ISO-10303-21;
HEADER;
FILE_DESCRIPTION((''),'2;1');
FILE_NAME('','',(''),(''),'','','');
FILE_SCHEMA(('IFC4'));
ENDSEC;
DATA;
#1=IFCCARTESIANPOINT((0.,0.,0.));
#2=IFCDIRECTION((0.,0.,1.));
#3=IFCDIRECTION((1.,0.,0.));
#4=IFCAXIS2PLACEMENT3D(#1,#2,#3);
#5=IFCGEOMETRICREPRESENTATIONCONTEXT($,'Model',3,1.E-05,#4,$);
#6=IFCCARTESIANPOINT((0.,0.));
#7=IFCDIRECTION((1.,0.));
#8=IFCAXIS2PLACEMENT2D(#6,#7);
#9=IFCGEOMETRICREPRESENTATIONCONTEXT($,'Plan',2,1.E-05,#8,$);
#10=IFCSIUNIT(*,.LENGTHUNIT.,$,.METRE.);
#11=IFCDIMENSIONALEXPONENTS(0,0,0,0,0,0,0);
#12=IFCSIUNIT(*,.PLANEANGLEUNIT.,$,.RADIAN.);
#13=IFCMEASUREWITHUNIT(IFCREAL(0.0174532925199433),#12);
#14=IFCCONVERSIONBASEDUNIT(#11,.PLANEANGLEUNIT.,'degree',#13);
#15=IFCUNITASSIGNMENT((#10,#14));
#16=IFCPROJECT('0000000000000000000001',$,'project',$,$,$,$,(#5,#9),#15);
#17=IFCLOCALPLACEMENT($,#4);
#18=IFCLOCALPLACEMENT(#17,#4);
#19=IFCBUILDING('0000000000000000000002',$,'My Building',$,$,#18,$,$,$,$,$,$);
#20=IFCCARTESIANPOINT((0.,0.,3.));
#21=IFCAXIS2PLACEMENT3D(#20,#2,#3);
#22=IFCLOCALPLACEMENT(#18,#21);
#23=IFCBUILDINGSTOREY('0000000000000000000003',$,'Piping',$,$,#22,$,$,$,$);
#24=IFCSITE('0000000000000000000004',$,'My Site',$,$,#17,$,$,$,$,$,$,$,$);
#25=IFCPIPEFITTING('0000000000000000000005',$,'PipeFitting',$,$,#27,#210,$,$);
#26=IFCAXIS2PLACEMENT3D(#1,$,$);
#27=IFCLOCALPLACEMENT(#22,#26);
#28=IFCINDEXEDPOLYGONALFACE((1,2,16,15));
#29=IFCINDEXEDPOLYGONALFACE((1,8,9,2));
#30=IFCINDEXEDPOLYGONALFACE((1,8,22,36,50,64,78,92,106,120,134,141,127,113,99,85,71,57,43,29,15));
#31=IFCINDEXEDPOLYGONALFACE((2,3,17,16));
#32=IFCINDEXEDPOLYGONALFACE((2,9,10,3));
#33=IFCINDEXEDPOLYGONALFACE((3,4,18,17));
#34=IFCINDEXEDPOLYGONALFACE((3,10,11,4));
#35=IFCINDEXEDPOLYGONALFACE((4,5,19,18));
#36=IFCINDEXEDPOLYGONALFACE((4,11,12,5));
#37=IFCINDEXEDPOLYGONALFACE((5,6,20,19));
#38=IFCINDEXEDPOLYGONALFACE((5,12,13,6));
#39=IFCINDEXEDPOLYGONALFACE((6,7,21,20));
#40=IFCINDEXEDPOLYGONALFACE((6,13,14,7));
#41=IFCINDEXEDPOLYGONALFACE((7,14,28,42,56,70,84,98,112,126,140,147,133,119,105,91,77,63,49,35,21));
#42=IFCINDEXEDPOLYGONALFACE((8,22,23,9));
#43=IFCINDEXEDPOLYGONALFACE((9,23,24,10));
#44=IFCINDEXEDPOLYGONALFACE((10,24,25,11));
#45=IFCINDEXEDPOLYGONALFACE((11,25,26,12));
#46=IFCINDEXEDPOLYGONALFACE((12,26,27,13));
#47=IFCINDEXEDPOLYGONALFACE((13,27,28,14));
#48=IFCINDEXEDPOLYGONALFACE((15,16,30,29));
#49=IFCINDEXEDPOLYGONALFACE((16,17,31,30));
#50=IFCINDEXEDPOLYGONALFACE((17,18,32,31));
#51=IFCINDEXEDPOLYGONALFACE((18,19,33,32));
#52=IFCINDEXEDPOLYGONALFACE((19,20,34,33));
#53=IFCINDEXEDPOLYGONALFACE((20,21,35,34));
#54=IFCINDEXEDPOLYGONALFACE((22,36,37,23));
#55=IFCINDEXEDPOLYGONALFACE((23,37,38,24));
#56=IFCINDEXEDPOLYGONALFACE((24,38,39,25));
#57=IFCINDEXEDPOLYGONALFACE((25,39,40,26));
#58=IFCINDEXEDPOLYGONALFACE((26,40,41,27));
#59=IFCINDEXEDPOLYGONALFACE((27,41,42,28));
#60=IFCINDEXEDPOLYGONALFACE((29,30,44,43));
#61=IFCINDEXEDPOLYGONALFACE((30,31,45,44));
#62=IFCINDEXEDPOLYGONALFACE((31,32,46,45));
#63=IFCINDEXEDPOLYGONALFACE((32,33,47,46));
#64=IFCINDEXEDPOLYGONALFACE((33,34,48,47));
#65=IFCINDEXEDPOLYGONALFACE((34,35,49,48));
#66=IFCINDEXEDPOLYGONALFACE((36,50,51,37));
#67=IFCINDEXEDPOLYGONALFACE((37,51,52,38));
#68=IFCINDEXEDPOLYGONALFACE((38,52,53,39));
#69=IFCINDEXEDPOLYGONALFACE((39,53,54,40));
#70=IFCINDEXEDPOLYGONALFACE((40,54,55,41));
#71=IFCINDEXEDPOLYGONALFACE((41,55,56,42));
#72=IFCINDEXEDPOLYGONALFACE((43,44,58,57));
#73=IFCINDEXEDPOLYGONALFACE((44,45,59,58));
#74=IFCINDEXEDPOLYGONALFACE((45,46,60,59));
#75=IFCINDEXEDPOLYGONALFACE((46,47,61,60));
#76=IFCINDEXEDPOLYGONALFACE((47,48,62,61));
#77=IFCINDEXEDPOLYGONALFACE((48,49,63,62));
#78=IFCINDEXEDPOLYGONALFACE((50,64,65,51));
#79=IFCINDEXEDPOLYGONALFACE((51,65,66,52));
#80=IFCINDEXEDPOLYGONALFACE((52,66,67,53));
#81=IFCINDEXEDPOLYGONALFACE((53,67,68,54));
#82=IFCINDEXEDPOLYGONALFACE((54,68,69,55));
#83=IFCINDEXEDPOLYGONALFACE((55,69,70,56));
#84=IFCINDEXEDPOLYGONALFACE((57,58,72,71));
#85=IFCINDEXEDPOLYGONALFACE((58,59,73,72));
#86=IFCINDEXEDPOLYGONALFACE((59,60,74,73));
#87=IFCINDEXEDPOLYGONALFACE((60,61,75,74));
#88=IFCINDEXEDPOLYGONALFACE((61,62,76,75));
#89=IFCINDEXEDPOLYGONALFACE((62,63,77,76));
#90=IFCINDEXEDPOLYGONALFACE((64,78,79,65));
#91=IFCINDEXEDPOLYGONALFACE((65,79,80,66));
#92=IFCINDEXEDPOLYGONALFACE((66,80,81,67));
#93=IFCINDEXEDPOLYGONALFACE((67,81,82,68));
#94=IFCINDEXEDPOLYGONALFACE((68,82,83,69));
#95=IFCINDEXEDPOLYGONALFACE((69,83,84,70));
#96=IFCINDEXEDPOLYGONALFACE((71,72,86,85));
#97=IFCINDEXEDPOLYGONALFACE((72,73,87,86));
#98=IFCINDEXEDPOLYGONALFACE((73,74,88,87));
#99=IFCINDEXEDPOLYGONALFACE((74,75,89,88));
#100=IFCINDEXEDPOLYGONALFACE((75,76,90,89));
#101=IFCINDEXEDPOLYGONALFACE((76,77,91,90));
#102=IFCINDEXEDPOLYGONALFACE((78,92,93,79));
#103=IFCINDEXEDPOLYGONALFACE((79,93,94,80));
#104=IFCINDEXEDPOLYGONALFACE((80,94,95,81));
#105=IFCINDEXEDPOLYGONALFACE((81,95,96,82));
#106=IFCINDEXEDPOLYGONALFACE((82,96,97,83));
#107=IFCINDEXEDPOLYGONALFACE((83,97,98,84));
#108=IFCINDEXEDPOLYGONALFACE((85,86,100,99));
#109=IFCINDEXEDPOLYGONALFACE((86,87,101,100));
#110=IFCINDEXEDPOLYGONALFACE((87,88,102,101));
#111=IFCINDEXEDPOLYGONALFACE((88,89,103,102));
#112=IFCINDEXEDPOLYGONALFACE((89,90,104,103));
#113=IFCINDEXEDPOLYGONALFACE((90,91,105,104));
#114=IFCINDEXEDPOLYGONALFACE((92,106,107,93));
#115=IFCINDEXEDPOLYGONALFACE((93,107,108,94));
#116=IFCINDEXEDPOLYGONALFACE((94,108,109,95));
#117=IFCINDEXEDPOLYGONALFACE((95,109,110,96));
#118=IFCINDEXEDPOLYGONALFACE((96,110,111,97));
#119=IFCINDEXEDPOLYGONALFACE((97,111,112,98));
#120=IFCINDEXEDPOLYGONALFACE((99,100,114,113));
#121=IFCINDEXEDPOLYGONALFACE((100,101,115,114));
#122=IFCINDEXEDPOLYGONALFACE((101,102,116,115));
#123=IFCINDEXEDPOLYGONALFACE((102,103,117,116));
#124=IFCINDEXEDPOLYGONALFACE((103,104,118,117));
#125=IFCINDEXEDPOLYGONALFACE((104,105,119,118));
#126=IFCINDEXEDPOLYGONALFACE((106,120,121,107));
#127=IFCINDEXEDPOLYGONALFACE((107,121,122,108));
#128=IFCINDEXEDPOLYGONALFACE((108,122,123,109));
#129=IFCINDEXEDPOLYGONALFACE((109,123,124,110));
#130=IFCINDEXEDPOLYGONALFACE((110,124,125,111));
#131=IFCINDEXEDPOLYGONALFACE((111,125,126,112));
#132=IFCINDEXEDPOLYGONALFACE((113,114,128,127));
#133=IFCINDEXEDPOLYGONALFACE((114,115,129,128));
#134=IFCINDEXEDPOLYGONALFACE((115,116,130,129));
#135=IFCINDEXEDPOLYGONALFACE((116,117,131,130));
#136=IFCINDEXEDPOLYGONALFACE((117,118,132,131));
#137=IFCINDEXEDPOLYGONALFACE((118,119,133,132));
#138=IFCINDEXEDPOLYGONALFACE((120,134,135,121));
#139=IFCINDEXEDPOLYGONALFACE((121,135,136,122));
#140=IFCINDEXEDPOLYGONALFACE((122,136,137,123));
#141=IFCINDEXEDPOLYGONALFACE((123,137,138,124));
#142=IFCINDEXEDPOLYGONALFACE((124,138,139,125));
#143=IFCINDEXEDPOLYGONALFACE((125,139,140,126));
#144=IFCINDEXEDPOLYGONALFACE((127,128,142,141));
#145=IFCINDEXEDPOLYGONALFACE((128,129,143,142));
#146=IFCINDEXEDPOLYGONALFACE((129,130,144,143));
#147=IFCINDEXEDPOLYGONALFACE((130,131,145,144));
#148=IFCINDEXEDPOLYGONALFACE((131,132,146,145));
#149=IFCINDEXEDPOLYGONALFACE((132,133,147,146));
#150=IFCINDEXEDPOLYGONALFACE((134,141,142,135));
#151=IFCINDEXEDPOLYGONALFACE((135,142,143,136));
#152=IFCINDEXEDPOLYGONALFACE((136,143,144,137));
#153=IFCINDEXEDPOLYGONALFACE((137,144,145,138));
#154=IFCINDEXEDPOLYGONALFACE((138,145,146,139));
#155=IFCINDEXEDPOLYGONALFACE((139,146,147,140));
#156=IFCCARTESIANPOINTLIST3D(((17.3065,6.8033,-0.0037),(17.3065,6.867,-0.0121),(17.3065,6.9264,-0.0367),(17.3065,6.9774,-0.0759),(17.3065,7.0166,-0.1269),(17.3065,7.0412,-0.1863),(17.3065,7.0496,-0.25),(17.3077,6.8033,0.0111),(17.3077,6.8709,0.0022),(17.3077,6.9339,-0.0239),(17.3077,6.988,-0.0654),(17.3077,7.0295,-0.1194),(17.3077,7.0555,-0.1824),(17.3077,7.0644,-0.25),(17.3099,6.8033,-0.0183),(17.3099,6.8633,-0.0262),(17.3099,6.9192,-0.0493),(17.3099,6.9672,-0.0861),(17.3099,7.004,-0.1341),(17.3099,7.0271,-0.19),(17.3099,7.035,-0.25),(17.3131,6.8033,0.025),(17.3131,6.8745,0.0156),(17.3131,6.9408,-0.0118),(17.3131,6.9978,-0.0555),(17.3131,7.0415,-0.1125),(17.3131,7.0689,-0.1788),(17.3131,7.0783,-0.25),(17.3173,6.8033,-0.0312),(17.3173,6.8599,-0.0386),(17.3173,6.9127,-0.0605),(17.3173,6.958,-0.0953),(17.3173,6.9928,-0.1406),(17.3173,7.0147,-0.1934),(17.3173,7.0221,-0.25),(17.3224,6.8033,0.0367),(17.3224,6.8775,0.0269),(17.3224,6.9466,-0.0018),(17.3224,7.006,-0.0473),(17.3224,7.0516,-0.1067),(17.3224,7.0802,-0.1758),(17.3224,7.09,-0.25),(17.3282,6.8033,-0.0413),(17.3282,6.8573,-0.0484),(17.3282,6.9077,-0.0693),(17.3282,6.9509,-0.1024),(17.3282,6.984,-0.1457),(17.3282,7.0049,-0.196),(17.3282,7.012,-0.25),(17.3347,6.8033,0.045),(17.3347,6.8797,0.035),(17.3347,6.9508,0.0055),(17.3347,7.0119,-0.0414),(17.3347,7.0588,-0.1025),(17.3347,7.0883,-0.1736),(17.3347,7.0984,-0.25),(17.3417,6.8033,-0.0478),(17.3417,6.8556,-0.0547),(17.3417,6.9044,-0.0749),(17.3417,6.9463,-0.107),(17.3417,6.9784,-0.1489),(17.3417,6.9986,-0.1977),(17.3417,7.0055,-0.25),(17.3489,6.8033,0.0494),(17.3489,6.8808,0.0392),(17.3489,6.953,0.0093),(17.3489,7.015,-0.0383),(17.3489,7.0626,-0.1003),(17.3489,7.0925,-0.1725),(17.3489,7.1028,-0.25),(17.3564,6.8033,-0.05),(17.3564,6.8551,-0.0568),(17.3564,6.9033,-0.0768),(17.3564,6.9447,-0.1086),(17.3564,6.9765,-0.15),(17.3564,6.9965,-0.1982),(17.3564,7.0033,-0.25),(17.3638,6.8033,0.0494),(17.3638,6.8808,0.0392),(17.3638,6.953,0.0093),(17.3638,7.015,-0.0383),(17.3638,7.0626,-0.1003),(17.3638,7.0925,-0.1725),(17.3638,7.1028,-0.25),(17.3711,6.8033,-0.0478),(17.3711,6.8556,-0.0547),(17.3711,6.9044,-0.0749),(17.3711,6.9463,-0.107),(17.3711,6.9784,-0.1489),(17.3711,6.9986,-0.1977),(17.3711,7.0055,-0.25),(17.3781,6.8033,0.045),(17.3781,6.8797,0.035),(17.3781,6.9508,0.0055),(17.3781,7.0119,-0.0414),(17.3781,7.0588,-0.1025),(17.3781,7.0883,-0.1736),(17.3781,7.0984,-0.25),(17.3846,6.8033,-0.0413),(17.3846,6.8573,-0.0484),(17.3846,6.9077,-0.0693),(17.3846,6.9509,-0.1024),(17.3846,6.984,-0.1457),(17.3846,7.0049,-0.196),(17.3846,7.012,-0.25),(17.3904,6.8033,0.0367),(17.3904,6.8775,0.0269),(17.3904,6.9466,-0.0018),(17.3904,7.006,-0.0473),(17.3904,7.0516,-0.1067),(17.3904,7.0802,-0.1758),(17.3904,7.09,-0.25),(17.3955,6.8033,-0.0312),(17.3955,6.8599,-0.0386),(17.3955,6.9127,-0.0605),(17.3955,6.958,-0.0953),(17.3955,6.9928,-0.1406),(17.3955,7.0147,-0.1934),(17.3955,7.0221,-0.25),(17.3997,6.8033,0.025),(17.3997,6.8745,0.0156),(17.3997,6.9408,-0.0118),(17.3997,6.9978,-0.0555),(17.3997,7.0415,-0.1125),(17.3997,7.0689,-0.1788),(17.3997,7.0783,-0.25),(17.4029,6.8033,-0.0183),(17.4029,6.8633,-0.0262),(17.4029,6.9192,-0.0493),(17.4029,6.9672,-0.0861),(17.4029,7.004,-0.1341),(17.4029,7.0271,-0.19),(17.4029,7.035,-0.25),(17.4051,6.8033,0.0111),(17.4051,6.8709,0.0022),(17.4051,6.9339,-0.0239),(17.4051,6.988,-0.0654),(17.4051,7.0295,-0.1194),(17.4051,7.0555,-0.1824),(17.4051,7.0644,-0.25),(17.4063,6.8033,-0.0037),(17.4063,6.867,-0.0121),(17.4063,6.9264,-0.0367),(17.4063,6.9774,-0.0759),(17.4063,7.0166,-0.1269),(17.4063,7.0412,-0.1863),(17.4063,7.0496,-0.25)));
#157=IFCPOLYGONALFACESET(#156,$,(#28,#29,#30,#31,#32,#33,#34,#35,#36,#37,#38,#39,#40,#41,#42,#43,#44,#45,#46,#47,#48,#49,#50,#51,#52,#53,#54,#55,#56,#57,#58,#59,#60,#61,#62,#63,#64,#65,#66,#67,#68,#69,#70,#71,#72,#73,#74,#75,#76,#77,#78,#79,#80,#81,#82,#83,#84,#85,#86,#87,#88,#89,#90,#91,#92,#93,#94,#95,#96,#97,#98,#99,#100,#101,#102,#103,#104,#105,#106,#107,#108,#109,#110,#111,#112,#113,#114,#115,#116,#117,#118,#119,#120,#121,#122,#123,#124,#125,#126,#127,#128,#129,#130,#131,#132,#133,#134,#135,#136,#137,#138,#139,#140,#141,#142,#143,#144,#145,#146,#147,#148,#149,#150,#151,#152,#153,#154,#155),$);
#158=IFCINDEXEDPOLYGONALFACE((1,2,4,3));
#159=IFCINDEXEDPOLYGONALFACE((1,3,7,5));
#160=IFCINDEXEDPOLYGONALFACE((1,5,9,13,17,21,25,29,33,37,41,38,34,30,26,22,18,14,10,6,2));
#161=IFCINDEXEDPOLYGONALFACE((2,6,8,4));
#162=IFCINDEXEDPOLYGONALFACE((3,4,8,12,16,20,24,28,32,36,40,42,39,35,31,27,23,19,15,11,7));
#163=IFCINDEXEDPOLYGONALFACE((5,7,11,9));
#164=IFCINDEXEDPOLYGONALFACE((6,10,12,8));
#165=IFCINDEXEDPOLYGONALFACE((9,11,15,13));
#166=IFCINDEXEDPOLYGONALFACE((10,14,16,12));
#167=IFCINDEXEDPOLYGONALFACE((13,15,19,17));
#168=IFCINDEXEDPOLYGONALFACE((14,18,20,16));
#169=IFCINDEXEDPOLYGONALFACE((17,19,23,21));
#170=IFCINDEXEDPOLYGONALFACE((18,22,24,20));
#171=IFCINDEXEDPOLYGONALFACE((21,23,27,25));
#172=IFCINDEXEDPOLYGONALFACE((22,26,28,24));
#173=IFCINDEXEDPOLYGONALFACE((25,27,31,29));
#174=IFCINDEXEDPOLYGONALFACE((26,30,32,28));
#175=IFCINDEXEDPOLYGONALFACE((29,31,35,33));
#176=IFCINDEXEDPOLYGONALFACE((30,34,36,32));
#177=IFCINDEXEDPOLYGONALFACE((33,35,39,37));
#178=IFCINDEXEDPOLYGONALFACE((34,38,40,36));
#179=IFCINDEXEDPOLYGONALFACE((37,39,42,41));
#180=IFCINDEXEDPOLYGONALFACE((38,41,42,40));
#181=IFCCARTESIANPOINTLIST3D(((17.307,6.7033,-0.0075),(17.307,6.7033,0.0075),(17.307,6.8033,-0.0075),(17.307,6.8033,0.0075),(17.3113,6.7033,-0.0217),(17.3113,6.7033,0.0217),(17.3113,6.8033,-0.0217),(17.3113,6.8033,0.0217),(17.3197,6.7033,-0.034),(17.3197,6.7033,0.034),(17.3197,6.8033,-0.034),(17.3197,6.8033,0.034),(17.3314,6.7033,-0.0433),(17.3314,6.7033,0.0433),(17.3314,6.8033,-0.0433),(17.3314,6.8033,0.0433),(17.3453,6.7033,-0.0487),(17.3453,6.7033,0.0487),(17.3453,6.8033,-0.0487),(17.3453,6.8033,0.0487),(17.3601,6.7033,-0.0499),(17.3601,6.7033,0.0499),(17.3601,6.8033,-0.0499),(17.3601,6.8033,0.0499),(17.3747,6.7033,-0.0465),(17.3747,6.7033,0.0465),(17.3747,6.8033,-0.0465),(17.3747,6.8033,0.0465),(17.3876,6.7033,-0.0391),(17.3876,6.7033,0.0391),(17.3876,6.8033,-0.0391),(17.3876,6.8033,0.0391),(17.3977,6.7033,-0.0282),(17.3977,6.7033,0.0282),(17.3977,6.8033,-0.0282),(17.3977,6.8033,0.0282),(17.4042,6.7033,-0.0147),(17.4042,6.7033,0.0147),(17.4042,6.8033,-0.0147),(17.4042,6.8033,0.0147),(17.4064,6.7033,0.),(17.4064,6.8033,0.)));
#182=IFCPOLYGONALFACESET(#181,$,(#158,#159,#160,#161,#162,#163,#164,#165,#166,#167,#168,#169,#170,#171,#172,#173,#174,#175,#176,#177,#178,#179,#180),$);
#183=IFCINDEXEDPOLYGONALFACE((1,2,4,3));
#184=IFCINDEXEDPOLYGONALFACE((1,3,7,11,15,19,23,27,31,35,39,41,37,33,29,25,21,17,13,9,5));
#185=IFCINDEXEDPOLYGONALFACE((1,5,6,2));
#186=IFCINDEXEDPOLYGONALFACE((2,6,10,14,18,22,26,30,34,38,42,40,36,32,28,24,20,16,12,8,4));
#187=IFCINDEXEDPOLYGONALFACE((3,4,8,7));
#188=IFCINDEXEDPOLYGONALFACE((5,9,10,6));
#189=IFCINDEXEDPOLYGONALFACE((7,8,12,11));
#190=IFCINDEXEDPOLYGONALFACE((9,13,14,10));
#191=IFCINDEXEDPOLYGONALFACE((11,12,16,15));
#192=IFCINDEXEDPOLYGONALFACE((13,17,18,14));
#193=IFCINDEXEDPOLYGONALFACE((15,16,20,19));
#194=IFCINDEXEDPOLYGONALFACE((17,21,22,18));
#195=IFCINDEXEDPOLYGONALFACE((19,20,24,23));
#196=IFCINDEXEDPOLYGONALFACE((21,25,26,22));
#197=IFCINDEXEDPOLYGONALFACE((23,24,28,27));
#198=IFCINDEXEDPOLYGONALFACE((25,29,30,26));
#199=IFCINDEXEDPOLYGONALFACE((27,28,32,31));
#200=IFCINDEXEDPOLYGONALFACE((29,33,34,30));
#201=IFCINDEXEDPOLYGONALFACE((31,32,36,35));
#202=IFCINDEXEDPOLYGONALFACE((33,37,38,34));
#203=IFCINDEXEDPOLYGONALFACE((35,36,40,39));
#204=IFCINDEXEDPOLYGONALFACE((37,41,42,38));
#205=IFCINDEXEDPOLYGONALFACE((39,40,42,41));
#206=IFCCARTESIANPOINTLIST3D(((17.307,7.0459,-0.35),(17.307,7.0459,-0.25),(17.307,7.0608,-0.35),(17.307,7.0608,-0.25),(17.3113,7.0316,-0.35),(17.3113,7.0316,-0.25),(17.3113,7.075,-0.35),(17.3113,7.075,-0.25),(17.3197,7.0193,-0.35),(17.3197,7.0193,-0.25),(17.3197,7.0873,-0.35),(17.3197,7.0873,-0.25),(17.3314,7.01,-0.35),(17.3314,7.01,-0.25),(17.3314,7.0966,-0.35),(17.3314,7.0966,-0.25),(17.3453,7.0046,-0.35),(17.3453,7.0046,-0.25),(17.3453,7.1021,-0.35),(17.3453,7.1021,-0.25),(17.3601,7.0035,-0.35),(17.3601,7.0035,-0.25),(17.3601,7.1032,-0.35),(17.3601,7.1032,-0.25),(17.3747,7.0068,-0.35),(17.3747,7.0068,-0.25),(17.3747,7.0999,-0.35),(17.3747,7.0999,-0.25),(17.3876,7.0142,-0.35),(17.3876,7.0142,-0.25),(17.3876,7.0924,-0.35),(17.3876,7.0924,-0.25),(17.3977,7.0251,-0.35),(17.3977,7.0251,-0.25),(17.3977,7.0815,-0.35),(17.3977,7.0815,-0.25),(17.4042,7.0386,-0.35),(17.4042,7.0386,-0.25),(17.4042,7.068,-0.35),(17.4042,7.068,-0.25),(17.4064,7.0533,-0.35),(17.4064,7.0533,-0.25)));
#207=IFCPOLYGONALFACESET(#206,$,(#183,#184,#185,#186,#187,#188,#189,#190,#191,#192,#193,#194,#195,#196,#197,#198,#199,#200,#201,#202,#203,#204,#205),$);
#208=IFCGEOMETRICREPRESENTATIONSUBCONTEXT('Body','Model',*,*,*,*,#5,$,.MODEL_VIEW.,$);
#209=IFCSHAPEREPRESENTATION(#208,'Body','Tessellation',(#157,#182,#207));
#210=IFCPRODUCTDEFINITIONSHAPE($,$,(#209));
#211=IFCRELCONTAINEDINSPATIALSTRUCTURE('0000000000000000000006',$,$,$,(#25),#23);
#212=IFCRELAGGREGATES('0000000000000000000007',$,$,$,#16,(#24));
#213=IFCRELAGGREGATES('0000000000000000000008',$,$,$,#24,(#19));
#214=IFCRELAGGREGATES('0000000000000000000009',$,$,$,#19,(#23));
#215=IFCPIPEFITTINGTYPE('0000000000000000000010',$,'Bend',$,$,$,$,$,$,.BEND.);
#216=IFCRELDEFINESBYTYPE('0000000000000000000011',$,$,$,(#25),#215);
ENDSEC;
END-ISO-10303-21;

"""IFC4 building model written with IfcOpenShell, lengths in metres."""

from ifc_helpers import new_model, entity, si_unit, converted_unit, frame, origin_with_axes, origin_2d_with_axis, place, context, subcontext, project, spatial, circle, extrude, source, transform, mapped, type_object, type_shapes, element, save


model = new_model("IFC4")

# Units and contexts
model_context = context("Model", 3, precision=1e-05, world=origin_with_axes())
plan_context = context("Plan", 2, precision=1e-05, world=origin_2d_with_axis())
body_context = subcontext(model_context, "Body", "Model", "MODEL_VIEW")
ifc_project = project(units=[si_unit("LENGTHUNIT", "METRE"), converted_unit("PLANEANGLEUNIT", "degree", entity("IfcReal", 0.0174532925199433), si_unit("PLANEANGLEUNIT", "RADIAN"), dimensions=[0, 0, 0, 0, 0, 0, 0])], contexts=[model_context, plan_context])

# Site, building, storey
site_placement = place(None, origin_with_axes())
site = spatial("IfcSite", under=ifc_project, at=site_placement, Name="My Site")
building_placement = place(site_placement, origin_with_axes())
building = spatial("IfcBuilding", under=site, at=building_placement, Name="My Building")
storey_placement = place(building_placement, frame((0.0, 0.0, 3.0), z_axis=(0.0, 0.0, 1.0), x_axis=(1.0, 0.0, 0.0)))
storey = spatial("IfcBuildingStorey", under=building, at=storey_placement, Name="Piping")

# Shared definitions
pipe_fitting_type = type_object("IfcPipeFittingType", Name="Bend", PredefinedType="BEND")
shared_shape = source(origin_with_axes(), body_context, "Body", "SolidModel", [
    entity("IfcSweptDiskSolid", entity("IfcIndexedPolyCurve", entity("IfcCartesianPointList3D", [[0.0, 0.0, -0.1], [0.0, -0.0732, -0.2768], [0.0, -0.25, -0.35]]), [entity("IfcArcIndex", [1, 2, 3])]), 0.05),
    extrude(circle(Radius=0.05), origin_with_axes(), (0.0, 0.0, -1.0), 0.1),
    extrude(circle(Radius=0.05), frame((0.0, -0.25, -0.35), z_axis=(0.0, -1.0, 0.0), x_axis=(1.0, 0.0, 0.0)), (0.0, 0.0, 1.0), 0.1),
])
type_shapes(pipe_fitting_type, [shared_shape])

# Pipe fitting
for number, where, z_axis, x_axis, name in (
    (1, (17.3564, 6.7033, 0.0), (0.0, -1.0, 0.0), (1.0, 0.0, 0.0), "PipeFitting"),
):
    element("IfcPipeFitting", number, at=place(storey_placement, frame(where, z_axis=z_axis, x_axis=x_axis)), inside=storey, type_object=pipe_fitting_type, Name=name, context=body_context, shape_type="MappedRepresentation", body=[
        mapped(shared_shape, transform((0.0, 0.0, 0.0), x_axis=(1.0, 0.0, 0.0), y_axis=(0.0, 1.0, 0.0), z_axis=(0.0, 0.0, 1.0), scale=1.0)),
    ])

save(model, "model.ifc")
